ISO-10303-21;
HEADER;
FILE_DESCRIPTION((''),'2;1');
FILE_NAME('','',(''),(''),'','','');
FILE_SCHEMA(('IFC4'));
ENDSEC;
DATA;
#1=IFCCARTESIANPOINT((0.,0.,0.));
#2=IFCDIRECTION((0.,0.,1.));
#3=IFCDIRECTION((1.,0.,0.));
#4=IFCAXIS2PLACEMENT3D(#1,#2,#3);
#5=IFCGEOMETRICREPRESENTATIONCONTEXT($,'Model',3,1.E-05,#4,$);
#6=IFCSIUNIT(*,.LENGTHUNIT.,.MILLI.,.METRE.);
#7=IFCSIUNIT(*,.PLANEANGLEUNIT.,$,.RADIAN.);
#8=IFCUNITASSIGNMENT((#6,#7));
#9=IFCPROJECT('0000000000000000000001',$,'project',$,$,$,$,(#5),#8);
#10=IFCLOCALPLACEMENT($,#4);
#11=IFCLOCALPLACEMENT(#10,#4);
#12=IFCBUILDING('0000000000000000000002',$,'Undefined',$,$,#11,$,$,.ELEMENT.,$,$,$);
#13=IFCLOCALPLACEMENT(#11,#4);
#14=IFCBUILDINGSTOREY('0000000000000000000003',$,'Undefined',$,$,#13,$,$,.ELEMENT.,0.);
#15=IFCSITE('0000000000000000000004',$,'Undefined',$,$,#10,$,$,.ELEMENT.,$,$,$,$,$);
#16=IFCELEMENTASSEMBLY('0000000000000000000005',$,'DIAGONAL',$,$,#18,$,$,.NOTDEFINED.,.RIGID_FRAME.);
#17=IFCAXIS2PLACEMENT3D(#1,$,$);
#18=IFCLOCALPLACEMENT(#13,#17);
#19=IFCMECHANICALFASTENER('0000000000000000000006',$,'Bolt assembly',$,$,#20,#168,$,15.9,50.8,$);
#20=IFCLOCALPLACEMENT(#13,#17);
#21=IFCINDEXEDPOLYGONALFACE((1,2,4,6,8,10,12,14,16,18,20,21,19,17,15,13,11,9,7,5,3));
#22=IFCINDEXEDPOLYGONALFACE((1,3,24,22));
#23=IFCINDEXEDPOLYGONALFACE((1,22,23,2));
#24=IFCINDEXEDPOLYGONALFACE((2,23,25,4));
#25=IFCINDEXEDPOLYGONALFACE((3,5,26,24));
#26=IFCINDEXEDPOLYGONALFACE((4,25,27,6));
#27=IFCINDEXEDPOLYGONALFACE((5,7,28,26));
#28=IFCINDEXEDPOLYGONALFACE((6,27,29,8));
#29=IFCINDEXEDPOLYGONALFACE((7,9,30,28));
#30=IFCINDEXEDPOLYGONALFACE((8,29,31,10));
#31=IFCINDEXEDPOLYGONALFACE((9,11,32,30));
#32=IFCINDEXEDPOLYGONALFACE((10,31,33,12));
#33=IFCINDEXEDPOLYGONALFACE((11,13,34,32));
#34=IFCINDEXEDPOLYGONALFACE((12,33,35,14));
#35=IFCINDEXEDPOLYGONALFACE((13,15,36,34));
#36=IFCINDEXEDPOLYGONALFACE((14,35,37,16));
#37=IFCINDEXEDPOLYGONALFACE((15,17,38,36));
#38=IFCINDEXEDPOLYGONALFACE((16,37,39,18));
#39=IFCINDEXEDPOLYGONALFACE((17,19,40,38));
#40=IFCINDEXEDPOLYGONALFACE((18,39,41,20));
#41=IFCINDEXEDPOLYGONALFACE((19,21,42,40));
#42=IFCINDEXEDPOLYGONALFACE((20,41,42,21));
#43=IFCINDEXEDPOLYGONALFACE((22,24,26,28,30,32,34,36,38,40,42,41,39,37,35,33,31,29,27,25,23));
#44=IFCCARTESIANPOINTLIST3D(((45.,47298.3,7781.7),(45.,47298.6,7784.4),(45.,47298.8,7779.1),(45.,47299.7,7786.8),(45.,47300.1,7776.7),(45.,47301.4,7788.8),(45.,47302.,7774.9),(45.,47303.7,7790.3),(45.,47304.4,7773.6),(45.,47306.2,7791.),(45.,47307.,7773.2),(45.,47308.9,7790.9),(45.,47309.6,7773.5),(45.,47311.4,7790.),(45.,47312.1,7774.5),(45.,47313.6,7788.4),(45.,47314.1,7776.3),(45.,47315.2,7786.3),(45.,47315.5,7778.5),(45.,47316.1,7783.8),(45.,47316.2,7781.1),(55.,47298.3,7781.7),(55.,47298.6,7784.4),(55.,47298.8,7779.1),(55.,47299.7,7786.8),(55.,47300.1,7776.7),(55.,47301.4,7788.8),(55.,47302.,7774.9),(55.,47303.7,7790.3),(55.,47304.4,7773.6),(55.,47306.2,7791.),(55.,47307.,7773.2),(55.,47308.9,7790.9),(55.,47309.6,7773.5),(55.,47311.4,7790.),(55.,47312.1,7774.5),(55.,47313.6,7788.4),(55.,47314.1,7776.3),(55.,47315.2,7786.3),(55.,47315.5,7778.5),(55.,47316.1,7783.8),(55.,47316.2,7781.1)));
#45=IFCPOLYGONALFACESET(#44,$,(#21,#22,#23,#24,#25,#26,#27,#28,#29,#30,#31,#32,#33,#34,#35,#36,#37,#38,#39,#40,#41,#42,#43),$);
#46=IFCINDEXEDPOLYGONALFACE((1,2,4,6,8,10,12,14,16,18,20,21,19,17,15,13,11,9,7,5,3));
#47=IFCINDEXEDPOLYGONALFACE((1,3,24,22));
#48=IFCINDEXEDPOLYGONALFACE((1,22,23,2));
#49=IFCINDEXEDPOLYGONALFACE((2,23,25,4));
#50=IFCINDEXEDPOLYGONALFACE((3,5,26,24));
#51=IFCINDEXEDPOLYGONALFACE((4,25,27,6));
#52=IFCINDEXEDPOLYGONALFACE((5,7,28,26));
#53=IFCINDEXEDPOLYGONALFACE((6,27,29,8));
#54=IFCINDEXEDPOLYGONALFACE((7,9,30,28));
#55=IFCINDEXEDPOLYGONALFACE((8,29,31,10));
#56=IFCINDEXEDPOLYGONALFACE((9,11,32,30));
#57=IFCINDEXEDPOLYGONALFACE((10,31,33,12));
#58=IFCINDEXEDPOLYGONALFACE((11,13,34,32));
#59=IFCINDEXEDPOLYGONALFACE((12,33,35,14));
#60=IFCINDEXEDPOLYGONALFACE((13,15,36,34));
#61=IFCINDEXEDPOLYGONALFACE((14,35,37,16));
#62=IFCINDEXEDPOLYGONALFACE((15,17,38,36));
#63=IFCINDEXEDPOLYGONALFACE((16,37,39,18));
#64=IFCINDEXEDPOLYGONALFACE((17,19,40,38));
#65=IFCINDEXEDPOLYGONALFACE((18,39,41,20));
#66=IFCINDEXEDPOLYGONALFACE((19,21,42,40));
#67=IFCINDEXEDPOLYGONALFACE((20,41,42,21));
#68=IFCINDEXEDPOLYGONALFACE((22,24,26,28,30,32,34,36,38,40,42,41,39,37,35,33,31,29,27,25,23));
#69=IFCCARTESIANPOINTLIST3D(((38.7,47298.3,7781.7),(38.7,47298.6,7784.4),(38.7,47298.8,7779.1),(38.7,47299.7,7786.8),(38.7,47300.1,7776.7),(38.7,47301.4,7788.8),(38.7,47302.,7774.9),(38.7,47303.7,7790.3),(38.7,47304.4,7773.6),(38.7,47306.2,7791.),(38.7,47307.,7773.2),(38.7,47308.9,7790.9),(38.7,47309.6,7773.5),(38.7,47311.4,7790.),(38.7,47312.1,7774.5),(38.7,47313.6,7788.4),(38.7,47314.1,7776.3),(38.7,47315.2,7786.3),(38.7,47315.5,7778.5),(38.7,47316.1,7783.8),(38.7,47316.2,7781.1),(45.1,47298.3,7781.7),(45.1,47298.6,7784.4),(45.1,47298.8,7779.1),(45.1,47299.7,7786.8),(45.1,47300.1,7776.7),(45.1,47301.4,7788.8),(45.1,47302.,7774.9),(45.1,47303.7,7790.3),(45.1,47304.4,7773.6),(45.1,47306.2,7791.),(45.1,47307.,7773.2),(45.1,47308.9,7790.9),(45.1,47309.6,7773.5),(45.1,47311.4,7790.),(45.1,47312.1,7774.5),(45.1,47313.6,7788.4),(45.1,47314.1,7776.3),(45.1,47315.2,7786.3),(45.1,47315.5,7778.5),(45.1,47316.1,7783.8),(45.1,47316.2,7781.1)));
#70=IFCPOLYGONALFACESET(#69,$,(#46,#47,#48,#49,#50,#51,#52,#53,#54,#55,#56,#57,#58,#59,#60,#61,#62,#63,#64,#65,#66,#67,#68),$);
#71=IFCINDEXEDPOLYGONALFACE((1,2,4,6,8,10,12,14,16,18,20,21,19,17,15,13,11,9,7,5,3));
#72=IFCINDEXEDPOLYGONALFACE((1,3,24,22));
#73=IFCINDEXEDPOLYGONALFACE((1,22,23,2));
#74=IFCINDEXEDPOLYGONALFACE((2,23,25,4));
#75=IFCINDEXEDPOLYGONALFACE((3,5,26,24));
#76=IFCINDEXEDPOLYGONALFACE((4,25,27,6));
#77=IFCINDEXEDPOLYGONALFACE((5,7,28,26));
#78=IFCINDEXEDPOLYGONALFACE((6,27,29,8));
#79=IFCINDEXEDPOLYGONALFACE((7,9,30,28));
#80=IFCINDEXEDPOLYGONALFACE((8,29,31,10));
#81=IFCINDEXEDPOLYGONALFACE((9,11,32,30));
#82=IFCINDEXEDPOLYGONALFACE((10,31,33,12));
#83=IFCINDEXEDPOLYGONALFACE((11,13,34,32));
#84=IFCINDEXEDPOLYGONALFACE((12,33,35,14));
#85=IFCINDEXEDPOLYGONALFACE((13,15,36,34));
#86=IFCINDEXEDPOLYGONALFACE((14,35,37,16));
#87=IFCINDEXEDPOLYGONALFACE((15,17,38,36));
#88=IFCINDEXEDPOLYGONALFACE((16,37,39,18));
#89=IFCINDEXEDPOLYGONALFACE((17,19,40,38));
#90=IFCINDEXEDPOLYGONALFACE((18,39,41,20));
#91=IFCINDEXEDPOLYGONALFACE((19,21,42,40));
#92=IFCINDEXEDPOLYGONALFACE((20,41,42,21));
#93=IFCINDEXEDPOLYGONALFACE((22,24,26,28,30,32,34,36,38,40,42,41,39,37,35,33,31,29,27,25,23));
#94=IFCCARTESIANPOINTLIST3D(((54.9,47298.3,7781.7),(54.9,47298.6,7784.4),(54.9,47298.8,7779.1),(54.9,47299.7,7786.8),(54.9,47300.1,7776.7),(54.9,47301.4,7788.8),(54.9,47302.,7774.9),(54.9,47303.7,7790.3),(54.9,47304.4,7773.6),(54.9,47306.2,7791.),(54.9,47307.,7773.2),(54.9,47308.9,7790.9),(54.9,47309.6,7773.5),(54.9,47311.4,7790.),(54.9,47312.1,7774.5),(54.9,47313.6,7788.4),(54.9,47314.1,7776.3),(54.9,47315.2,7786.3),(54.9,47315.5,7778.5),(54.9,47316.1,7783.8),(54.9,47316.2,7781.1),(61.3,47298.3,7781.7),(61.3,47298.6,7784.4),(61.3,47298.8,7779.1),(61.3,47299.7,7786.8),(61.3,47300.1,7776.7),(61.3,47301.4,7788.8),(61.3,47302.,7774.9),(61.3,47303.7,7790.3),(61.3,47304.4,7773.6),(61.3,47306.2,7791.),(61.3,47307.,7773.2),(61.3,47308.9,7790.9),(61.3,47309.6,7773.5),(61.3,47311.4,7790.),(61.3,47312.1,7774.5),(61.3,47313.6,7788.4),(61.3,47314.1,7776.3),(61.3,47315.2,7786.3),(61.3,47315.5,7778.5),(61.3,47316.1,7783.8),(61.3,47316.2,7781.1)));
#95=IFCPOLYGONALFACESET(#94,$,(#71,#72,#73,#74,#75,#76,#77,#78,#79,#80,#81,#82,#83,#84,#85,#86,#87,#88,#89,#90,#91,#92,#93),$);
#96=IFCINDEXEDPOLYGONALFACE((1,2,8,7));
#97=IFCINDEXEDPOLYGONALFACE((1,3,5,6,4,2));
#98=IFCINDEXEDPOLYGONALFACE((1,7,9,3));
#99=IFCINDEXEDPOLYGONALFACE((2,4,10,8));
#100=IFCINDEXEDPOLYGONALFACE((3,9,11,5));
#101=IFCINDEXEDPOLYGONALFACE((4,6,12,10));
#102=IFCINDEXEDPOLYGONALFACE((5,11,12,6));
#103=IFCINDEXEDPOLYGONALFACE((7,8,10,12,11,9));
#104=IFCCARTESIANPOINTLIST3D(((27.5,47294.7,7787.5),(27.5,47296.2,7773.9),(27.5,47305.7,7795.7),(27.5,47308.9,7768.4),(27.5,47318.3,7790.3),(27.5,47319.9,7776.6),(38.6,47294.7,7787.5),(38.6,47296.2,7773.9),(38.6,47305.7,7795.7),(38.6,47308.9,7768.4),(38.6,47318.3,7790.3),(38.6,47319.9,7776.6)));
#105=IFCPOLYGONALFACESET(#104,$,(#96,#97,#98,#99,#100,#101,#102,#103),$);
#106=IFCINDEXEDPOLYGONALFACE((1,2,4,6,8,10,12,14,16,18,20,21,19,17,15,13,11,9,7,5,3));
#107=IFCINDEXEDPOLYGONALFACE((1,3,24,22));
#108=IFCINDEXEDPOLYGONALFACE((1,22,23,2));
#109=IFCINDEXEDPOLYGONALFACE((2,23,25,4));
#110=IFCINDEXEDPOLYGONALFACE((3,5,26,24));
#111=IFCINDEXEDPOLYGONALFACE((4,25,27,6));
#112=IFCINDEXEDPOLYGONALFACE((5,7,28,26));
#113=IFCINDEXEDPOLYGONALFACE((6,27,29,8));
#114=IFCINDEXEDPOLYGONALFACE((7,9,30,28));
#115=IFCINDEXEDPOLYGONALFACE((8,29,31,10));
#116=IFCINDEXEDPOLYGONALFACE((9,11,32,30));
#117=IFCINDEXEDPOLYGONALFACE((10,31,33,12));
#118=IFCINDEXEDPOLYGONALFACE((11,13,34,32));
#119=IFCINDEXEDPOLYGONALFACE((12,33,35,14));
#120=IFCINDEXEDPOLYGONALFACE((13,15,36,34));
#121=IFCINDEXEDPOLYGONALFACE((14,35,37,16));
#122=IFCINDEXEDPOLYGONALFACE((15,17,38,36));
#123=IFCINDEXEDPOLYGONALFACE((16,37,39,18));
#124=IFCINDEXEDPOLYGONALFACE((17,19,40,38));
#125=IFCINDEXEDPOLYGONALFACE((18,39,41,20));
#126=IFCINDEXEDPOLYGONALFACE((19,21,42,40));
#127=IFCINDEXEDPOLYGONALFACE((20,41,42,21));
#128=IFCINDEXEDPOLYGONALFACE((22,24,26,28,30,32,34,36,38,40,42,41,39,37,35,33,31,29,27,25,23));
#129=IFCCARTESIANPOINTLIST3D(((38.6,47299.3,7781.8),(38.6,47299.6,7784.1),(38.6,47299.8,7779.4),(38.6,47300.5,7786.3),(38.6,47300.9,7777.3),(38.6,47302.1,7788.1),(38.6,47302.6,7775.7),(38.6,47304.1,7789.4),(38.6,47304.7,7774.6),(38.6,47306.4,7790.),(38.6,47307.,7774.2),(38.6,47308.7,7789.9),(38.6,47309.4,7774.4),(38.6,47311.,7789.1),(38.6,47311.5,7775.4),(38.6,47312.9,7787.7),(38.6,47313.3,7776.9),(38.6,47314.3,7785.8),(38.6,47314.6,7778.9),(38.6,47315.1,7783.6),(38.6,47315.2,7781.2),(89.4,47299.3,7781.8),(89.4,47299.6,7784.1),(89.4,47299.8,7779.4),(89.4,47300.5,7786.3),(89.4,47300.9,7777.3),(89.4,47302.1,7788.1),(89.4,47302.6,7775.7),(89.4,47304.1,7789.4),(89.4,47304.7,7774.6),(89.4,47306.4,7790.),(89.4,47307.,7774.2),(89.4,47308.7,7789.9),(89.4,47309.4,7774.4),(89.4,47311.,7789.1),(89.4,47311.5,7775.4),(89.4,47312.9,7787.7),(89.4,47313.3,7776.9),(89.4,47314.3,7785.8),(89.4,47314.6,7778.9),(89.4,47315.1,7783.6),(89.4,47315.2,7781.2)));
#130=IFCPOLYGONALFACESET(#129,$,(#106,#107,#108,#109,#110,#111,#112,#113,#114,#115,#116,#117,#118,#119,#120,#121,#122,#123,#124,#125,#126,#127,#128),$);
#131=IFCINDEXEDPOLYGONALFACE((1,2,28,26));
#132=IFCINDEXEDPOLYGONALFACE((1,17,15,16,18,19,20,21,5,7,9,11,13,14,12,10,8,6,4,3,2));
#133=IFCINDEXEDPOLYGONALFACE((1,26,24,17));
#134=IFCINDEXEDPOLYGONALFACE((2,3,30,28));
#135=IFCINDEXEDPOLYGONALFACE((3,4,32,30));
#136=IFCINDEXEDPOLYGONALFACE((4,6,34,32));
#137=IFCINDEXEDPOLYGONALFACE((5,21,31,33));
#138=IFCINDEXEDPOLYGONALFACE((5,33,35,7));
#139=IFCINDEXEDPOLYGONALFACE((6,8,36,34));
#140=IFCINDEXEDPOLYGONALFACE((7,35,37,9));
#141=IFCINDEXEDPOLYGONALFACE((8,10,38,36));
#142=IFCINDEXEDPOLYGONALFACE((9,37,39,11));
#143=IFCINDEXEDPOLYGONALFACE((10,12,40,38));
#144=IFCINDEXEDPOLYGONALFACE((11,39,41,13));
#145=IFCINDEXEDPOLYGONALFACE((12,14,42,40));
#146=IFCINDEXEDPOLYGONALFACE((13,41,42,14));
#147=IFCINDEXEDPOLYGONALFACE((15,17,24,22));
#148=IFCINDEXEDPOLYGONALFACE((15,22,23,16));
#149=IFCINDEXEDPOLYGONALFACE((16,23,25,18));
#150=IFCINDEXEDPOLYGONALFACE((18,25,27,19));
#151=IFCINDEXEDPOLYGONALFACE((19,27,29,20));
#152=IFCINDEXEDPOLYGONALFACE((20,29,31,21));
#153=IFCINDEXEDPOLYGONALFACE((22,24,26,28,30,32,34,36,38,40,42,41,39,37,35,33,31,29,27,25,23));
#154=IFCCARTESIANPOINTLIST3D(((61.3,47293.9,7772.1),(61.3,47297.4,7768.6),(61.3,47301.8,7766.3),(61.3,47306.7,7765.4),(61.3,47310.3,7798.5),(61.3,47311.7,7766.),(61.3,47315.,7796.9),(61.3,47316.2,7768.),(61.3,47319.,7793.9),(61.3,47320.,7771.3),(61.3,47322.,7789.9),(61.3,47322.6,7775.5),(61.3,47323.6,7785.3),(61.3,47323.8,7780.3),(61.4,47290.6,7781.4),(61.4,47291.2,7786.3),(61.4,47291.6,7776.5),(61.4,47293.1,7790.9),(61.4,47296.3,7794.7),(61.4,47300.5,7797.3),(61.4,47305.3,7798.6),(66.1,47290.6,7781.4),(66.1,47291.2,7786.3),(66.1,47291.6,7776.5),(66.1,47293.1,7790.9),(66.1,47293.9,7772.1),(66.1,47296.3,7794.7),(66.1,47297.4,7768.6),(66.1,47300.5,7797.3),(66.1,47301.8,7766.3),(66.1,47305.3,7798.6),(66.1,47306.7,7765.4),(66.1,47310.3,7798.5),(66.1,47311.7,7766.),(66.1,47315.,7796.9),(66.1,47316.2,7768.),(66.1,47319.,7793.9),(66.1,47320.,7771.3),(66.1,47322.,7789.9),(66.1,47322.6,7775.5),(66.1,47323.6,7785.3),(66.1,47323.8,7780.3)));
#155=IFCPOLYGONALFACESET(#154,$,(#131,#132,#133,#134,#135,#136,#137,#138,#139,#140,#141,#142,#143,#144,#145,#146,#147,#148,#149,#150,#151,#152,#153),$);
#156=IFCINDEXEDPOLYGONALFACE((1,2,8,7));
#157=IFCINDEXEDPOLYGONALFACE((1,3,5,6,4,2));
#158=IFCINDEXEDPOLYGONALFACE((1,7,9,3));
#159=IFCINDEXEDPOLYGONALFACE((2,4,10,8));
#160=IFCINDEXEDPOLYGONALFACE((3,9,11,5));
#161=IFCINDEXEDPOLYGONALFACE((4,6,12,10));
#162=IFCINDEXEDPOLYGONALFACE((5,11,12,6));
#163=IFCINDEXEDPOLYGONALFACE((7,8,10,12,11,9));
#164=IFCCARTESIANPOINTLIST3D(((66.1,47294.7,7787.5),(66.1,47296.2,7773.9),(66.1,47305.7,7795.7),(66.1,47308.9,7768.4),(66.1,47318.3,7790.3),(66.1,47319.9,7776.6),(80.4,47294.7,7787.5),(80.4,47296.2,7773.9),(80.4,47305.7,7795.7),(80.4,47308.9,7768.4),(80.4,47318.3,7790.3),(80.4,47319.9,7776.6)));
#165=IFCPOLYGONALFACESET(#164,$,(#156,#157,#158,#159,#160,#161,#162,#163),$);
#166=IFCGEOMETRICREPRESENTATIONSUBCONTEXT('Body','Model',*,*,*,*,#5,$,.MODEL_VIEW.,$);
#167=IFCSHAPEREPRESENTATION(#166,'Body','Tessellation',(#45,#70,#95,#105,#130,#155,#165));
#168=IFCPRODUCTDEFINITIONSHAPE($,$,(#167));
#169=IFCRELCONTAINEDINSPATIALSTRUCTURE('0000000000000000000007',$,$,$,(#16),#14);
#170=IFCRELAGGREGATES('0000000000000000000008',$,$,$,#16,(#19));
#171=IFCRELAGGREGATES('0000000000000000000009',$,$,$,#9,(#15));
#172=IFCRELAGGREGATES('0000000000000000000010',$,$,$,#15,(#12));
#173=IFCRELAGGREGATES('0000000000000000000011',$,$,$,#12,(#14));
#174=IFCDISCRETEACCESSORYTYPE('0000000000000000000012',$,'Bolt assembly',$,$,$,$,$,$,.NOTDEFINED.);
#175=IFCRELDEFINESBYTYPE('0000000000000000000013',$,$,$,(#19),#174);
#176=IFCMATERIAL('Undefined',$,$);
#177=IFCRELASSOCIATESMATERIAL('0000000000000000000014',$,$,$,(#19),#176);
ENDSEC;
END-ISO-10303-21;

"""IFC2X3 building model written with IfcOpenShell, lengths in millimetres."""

from ifc_helpers import new_model, si_unit, frame, origin_with_axes, origin_2d_with_axis, place, context, subcontext, project, spatial, polyline, circle, outline, extrude, source, transform, mapped, material, type_object, element, aggregate, save


model = new_model("IFC2X3")

# Units and contexts
model_context = context("Model", 3, precision=1e-05, world=origin_with_axes())
body_context = subcontext(model_context, "Body", "Model", "MODEL_VIEW")
ifc_project = project(units=[si_unit("LENGTHUNIT", "METRE", prefix="MILLI"), si_unit("PLANEANGLEUNIT", "RADIAN")], contexts=[model_context])

# Site, building, storey
site_placement = place(None, origin_with_axes())
site = spatial("IfcSite", under=ifc_project, at=site_placement, Name="Undefined", CompositionType="ELEMENT")
building_placement = place(site_placement, origin_with_axes())
building = spatial("IfcBuilding", under=site, at=building_placement, Name="Undefined", CompositionType="ELEMENT")
storey_placement = place(building_placement, origin_with_axes())
storey = spatial("IfcBuildingStorey", under=building, at=storey_placement, Name="Undefined", CompositionType="ELEMENT", Elevation=0.0)

# Shared definitions
discrete_accessory_type_1 = type_object("IfcDiscreteAccessoryType", Name="Bolt assembly")

# Shared definitions
ifc_material_1 = material(Name="Undefined")

# Element assembly, mechanical fastener
assembly_1_placement = place(storey_placement, origin_with_axes())
assembly_1 = element("IfcElementAssembly", 1, at=assembly_1_placement, inside=storey, Name="DIAGONAL", AssemblyPlace="NOTDEFINED", PredefinedType="RIGID_FRAME")
shared_shape_1 = source(origin_with_axes(), body_context, "Body", "SweptSolid", [
    extrude(circle(Radius=8.9, at=origin_2d_with_axis()), frame((0.0, 18.3, 0.0), z_axis=(0.0, 1.0, 0.0), x_axis=(1.0, 0.0, 0.0)), (0.0, 0.0, 1.0), 10.0),
    extrude(circle(Radius=8.9, at=origin_2d_with_axis()), frame((0.0, 12.1, 0.0), z_axis=(0.0, 1.0, 0.0), x_axis=(1.0, 0.0, 0.0)), (0.0, 0.0, 1.0), 6.3),
    extrude(circle(Radius=8.9, at=origin_2d_with_axis()), frame((0.0, 28.2, 0.0), z_axis=(0.0, 1.0, 0.0), x_axis=(1.0, 0.0, 0.0)), (0.0, 0.0, 1.0), 6.5),
    extrude(outline(polyline([(13.7, 0.0), (6.9, 11.9), (-6.9, 11.9), (-13.7, 0.0), (-6.9, -11.9), (6.9, -11.9), (13.7, 0.0)])), frame((0.0, 0.9, 0.0), z_axis=(0.0, 1.0, 0.0), x_axis=(1.0, 0.0, 0.0)), (0.0, 0.0, 1.0), 11.1),
    extrude(circle(Radius=7.9, at=origin_2d_with_axis()), frame((0.0, 12.0, 0.0), z_axis=(0.0, 1.0, 0.0), x_axis=(1.0, 0.0, 0.0)), (0.0, 0.0, 1.0), 50.8),
    extrude(circle(Radius=16.7, at=origin_2d_with_axis()), frame((0.0, 34.7, 0.0), z_axis=(0.0, 1.0, 0.0), x_axis=(1.0, 0.0, 0.0)), (0.0, 0.0, 1.0), 4.8),
    extrude(outline(polyline([(13.7, 0.0), (6.9, 11.9), (-6.9, 11.9), (-13.7, 0.0), (-6.9, -11.9), (6.9, -11.9), (13.7, 0.0)])), frame((0.0, 39.5, 0.0), z_axis=(0.0, 1.0, 0.0), x_axis=(1.0, 0.0, 0.0)), (0.0, 0.0, 1.0), 14.3),
])
mechanical_fastener_1_placement = place(assembly_1_placement, frame((26.6, 47307.3, 7782.1), z_axis=(-0.000002, -0.396036, -0.918235), x_axis=(-0.00001, 0.918235, -0.396036)))
mechanical_fastener_1 = element("IfcMechanicalFastener", 2, at=mechanical_fastener_1_placement, type_object=discrete_accessory_type_1, material=ifc_material_1, Name="Bolt assembly", NominalDiameter=15.9, NominalLength=50.8, context=body_context, shape_type="MappedRepresentation", body=[
    mapped(shared_shape_1, transform((0.0, 0.0, 0.0))),
])
aggregate(assembly_1, [mechanical_fastener_1])

save(model, "model.ifc")
